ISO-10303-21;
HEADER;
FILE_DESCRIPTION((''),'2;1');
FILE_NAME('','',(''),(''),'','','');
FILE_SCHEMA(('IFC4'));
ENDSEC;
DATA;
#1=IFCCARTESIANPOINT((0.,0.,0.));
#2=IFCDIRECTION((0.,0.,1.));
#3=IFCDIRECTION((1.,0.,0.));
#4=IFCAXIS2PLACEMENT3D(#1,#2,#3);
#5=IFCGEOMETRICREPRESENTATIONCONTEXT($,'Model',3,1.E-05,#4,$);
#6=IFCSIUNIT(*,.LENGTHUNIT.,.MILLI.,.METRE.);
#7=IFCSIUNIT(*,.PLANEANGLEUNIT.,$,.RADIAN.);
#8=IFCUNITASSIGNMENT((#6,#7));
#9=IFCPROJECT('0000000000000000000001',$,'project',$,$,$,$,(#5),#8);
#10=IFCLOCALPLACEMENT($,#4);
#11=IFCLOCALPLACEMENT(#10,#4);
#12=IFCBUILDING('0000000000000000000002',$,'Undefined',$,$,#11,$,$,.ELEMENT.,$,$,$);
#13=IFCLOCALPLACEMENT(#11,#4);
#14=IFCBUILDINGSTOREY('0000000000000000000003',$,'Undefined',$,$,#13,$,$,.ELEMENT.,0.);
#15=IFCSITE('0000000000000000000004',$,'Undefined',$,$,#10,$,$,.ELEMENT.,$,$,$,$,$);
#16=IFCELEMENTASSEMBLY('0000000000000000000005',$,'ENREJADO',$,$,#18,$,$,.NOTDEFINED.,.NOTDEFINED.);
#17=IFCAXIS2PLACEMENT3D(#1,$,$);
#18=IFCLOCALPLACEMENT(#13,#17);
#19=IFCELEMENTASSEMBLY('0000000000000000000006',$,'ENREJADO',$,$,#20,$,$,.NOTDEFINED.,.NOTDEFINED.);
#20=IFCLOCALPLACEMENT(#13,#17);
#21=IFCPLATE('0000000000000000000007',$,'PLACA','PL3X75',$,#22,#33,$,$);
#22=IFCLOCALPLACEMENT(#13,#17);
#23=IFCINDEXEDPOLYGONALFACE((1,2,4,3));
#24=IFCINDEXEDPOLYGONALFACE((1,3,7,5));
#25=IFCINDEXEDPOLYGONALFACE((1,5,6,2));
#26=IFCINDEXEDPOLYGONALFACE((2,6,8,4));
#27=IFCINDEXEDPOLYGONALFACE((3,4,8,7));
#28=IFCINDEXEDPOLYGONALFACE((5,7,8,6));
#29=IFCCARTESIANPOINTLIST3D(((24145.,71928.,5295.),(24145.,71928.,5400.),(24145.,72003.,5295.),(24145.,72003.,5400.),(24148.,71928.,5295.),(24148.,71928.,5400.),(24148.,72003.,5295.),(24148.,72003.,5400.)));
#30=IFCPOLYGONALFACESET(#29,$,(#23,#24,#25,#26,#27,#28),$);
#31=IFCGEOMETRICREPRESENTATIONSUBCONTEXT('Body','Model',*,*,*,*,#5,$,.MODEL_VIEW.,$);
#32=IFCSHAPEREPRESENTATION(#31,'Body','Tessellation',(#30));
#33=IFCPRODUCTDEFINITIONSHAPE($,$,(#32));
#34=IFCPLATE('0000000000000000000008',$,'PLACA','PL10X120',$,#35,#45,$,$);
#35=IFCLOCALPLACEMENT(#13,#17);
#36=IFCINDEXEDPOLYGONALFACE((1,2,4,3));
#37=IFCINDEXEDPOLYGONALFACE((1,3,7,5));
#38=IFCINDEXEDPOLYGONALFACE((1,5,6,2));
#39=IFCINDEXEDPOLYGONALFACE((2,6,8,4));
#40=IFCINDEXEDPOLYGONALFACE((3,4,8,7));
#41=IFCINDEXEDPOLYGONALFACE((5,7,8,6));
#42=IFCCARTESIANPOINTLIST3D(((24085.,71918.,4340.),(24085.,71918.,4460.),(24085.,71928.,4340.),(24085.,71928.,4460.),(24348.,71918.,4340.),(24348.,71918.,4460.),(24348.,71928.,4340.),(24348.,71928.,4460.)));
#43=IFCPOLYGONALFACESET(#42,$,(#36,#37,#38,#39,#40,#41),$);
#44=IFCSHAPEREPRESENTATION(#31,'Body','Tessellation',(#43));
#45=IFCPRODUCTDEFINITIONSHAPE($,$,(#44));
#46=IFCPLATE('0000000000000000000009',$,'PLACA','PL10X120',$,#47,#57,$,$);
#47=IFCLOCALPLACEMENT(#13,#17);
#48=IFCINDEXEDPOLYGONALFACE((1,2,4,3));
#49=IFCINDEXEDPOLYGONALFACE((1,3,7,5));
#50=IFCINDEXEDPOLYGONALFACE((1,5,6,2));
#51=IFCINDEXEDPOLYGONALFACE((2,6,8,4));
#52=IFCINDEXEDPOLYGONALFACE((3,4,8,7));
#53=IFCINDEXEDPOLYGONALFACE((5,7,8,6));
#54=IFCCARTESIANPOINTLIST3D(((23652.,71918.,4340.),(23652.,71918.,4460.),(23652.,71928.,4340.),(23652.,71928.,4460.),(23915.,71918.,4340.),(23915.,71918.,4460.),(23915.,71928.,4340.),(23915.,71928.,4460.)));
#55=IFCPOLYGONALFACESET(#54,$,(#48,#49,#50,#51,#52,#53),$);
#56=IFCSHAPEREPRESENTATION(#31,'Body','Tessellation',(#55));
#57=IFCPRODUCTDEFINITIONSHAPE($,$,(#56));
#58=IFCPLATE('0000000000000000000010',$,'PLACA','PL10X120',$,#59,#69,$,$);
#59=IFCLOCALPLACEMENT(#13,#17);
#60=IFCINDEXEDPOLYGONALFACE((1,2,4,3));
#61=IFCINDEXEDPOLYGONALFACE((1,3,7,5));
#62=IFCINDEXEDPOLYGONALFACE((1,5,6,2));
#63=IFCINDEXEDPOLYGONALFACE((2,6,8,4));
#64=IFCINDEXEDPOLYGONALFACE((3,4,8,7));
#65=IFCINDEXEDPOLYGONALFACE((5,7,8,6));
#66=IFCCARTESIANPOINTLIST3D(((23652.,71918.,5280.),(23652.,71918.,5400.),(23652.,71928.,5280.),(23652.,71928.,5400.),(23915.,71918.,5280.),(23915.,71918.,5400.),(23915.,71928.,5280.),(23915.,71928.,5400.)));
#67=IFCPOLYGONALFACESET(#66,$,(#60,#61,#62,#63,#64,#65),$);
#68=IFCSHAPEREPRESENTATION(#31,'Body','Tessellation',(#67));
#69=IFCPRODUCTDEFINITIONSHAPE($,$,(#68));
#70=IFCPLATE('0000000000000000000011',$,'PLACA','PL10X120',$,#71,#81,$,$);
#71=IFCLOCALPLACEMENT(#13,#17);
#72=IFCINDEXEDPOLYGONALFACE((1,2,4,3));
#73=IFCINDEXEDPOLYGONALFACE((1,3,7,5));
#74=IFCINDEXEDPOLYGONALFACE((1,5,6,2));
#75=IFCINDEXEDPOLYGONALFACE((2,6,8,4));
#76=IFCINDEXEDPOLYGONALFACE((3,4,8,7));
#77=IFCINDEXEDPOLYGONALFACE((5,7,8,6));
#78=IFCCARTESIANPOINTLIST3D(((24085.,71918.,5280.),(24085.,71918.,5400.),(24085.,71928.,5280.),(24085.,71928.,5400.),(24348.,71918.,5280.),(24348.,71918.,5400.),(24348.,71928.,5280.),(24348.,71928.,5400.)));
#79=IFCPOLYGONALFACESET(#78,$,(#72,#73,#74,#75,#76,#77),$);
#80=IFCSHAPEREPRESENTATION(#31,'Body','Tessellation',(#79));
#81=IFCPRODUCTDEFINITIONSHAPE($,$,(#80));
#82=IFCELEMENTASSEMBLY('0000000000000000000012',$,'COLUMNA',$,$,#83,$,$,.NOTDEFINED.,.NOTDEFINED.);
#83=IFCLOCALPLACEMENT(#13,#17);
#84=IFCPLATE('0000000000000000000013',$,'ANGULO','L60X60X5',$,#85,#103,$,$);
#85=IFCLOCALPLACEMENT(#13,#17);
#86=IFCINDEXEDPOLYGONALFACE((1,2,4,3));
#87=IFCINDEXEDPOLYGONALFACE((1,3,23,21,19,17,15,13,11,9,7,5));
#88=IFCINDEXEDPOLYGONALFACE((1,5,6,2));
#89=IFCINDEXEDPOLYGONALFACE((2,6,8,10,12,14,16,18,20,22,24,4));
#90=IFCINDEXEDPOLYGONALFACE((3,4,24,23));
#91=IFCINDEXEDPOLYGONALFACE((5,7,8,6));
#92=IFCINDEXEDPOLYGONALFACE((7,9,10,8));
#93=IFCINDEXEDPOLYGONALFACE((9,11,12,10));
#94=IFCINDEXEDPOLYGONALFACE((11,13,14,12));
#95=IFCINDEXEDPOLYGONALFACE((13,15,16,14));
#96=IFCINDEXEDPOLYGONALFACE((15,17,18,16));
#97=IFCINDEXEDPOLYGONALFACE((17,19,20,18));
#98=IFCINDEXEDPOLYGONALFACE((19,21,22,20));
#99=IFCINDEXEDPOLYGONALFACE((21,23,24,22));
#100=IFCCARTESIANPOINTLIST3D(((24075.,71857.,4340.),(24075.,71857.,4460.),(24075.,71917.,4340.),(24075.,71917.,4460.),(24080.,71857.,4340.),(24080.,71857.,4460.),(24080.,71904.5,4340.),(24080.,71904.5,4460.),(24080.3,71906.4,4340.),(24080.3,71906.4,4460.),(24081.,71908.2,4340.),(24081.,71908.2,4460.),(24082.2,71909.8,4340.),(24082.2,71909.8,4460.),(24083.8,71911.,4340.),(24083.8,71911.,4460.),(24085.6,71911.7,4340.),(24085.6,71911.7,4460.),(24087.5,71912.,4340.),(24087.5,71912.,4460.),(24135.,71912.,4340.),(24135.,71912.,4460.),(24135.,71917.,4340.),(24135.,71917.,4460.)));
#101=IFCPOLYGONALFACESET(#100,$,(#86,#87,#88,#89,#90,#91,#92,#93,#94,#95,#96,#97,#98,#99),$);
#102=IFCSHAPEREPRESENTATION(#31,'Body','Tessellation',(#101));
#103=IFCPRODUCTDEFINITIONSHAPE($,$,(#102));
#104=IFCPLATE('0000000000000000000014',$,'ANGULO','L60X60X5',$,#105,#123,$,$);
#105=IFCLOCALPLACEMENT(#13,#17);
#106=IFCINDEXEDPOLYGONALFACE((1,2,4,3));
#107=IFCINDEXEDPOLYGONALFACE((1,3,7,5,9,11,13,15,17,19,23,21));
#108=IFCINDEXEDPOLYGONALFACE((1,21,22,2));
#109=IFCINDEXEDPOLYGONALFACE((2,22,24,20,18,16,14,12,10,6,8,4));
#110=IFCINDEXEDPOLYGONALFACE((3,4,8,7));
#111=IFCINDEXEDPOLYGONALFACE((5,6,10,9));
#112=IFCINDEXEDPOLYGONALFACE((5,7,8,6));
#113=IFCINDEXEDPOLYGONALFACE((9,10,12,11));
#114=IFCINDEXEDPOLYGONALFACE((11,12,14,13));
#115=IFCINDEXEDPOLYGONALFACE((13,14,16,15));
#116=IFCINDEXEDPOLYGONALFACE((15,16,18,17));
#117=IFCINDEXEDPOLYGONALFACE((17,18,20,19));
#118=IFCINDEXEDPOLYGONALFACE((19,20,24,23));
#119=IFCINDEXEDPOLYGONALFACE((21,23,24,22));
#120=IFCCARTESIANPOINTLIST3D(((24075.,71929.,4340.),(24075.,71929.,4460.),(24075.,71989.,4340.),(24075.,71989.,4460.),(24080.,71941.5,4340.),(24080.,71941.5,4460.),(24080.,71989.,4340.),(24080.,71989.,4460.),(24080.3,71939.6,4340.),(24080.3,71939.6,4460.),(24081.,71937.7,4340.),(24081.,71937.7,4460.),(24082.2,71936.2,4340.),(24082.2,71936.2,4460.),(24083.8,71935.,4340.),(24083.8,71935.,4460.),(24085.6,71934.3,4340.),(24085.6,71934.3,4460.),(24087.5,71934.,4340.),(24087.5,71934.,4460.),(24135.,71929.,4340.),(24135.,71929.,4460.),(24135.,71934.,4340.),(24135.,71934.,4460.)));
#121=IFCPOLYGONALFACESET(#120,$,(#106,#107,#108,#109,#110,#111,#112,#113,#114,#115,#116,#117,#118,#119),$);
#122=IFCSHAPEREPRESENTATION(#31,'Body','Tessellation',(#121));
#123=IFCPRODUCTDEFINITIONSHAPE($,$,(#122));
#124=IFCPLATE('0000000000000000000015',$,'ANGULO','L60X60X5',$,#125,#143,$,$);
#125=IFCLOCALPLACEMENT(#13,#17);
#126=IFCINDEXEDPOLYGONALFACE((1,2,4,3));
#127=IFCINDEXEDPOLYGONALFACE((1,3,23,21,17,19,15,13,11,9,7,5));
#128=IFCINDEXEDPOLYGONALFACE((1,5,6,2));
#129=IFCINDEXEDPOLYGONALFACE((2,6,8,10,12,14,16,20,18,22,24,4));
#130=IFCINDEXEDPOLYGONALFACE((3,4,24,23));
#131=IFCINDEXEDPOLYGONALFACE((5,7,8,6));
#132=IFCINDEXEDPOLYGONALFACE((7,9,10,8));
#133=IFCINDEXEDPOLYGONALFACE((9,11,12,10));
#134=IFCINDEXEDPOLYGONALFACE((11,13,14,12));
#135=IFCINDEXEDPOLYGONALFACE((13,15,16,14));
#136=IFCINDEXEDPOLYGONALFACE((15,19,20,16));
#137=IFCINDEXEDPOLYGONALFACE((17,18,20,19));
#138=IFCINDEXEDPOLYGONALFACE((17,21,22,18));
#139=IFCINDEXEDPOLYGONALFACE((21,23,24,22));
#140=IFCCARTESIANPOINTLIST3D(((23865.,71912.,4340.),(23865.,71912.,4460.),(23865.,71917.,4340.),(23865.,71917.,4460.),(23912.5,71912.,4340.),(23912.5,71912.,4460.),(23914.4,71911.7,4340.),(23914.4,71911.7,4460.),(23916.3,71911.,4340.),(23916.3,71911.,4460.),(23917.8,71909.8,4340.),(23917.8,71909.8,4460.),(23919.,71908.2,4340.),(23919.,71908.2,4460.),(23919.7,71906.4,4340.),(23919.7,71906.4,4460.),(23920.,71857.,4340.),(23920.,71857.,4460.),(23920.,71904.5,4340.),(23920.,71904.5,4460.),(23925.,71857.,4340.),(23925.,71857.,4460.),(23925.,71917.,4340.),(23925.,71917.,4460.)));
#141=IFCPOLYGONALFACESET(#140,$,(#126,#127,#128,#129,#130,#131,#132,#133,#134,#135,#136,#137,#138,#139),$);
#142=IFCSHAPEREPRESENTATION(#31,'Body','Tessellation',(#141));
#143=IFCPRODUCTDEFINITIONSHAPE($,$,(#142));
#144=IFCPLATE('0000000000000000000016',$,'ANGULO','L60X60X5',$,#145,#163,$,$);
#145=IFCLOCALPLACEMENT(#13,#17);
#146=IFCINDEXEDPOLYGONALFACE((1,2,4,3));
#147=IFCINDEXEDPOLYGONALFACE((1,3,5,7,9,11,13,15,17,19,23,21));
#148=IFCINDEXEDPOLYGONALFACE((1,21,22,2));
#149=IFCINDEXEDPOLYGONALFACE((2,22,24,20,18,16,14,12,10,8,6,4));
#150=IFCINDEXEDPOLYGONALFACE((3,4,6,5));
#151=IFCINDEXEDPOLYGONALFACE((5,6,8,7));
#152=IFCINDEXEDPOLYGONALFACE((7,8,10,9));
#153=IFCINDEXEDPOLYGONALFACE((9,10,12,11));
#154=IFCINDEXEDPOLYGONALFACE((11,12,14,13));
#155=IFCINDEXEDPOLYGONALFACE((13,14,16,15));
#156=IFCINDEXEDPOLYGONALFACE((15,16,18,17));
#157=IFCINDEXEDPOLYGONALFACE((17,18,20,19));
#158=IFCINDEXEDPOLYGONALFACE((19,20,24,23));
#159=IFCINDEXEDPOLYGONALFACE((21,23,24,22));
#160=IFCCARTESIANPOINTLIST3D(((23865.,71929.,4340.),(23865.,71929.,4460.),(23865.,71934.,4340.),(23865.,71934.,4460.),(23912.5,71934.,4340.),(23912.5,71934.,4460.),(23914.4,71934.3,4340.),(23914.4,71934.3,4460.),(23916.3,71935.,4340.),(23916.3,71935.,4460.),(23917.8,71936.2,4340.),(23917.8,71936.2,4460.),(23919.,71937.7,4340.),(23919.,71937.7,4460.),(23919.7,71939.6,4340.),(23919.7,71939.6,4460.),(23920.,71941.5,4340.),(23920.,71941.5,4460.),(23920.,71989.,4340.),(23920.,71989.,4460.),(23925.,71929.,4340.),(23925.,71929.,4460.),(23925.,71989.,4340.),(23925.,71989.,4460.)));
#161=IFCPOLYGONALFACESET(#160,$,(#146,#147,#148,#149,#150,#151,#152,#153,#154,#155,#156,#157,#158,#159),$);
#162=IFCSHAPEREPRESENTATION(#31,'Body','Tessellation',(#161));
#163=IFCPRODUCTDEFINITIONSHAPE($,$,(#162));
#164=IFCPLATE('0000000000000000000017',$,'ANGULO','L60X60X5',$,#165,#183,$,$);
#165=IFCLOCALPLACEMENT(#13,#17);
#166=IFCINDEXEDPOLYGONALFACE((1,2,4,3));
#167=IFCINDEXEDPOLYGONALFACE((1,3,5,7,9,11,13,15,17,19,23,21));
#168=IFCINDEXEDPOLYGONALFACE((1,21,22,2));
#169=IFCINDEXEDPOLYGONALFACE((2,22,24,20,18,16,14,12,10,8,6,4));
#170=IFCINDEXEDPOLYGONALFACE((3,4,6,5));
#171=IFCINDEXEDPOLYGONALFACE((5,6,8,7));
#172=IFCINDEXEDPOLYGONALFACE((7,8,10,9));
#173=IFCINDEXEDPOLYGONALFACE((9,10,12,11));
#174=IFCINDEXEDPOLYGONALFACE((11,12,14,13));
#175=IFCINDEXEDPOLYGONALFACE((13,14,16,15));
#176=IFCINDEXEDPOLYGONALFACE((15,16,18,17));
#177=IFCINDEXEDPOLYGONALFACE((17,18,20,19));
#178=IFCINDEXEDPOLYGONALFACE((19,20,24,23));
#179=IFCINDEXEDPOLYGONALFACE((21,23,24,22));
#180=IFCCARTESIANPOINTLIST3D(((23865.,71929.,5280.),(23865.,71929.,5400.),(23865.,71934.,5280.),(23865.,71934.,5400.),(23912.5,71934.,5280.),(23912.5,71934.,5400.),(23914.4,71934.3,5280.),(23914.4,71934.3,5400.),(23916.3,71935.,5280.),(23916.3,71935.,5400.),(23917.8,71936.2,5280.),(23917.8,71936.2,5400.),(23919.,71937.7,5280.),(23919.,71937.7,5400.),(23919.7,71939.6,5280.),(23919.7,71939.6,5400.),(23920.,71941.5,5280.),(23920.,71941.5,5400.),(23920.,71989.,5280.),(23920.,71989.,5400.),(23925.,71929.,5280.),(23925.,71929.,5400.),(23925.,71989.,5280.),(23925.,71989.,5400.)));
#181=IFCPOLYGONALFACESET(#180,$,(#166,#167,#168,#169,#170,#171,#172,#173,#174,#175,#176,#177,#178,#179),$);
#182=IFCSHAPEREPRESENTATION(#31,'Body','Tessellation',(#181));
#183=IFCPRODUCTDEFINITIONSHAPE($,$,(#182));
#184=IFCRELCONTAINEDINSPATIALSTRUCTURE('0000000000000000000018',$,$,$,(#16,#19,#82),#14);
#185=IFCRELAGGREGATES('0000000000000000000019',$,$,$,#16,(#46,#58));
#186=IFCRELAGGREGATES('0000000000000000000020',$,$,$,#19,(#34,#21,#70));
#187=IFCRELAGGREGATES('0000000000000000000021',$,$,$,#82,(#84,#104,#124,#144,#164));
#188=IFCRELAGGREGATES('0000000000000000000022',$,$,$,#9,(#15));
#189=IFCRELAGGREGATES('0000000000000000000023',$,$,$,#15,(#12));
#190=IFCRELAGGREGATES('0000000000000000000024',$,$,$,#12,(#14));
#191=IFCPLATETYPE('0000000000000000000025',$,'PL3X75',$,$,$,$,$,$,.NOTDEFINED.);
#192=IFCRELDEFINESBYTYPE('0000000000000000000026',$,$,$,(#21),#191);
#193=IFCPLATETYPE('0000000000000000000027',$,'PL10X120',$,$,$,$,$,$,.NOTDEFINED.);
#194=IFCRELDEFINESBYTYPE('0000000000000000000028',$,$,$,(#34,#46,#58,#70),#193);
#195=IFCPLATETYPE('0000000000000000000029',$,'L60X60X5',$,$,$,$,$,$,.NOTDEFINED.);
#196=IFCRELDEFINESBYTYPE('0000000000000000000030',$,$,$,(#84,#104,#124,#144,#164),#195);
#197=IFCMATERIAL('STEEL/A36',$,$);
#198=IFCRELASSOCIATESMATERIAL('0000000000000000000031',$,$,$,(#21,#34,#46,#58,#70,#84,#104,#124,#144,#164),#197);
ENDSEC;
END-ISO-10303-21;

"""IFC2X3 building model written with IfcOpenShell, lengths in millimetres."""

from ifc_helpers import new_model, si_unit, frame, origin_with_axes, origin_2d_with_axis, place, context, subcontext, project, spatial, polyline, l_section, outline, extrude, material, type_object, element, aggregate, save


model = new_model("IFC2X3")

# Units and contexts
model_context = context("Model", 3, precision=1e-05, world=origin_with_axes())
body_context = subcontext(model_context, "Body", "Model", "MODEL_VIEW")
ifc_project = project(units=[si_unit("LENGTHUNIT", "METRE", prefix="MILLI"), si_unit("PLANEANGLEUNIT", "RADIAN")], contexts=[model_context])

# Site, building, storey
site_placement = place(None, origin_with_axes())
site = spatial("IfcSite", under=ifc_project, at=site_placement, Name="Undefined", CompositionType="ELEMENT")
building_placement = place(site_placement, origin_with_axes())
building = spatial("IfcBuilding", under=site, at=building_placement, Name="Undefined", CompositionType="ELEMENT")
storey_placement = place(building_placement, origin_with_axes())
storey = spatial("IfcBuildingStorey", under=building, at=storey_placement, Name="Undefined", CompositionType="ELEMENT", Elevation=0.0)

# Element assemblies
assembly_1_placement = place(storey_placement, origin_with_axes())
assembly_1 = element("IfcElementAssembly", 1, at=assembly_1_placement, inside=storey, Name="ENREJADO", AssemblyPlace="NOTDEFINED", PredefinedType="NOTDEFINED")
ifc_material_1 = material(Name="STEEL/A36")
assembly_2_placement = place(storey_placement, origin_with_axes())
assembly_2 = element("IfcElementAssembly", 2, at=assembly_2_placement, inside=storey, Name="ENREJADO", AssemblyPlace="NOTDEFINED", PredefinedType="NOTDEFINED")

# Plates
plate_type_1 = type_object("IfcPlateType", Name="PL3X75", PredefinedType="NOTDEFINED")
plate_1_placement = place(assembly_2_placement, frame((24146.5, 71928.0, 5295.0), z_axis=(1.0, 0.0, 0.0), x_axis=(0.0, 1.0, 0.0)))
plate_1 = element("IfcPlate", 3, at=plate_1_placement, type_object=plate_type_1, material=ifc_material_1, Name="PLACA", Description="PL3X75", context=body_context, shape_type="SweptSolid", body=[
    extrude(outline(polyline([(0.0, 0.0), (75.0, 0.0), (75.0, 105.0), (0.0, 105.0), (0.0, 0.0)])), frame((0.0, 0.0, -1.5), z_axis=(0.0, 0.0, 1.0), x_axis=(1.0, 0.0, 0.0)), (0.0, 0.0, 1.0), 3.0),
])
plate_type_2 = type_object("IfcPlateType", Name="PL10X120", PredefinedType="NOTDEFINED")
plate_2_placement = place(assembly_2_placement, frame((24085.0, 71923.0, 4400.0), z_axis=(0.0, 1.0, 0.0), x_axis=(1.0, 0.0, 0.0)))
plate_2 = element("IfcPlate", 4, at=plate_2_placement, type_object=plate_type_2, material=ifc_material_1, Name="PLACA", Description="PL10X120", context=body_context, shape_type="SweptSolid", body=[
    extrude(outline(polyline([(0.0, -60.0), (0.0, 60.0), (263.0, 60.0), (263.0, -60.0), (0.0, -60.0)])), frame((0.0, 0.0, -5.0), z_axis=(0.0, 0.0, 1.0), x_axis=(1.0, 0.0, 0.0)), (0.0, 0.0, 1.0), 10.0),
])
plate_3_placement = place(assembly_1_placement, frame((23915.0, 71923.0, 4400.0), z_axis=(0.0, 1.0, 0.0), x_axis=(-1.0, 0.0, 0.0)))
plate_3 = element("IfcPlate", 5, at=plate_3_placement, type_object=plate_type_2, material=ifc_material_1, Name="PLACA", Description="PL10X120", context=body_context, shape_type="SweptSolid", body=[
    extrude(outline(polyline([(0.0, -60.0), (0.0, 60.0), (263.0, 60.0), (263.0, -60.0), (0.0, -60.0)])), frame((0.0, 0.0, -5.0), z_axis=(0.0, 0.0, 1.0), x_axis=(1.0, 0.0, 0.0)), (0.0, 0.0, 1.0), 10.0),
])
plate_4_placement = place(assembly_1_placement, frame((23915.0, 71923.0, 5340.0), z_axis=(0.0, -1.0, 0.0), x_axis=(-1.0, 0.0, 0.0)))
plate_4 = element("IfcPlate", 6, at=plate_4_placement, type_object=plate_type_2, material=ifc_material_1, Name="PLACA", Description="PL10X120", context=body_context, shape_type="SweptSolid", body=[
    extrude(outline(polyline([(0.0, -60.0), (0.0, 60.0), (263.0, 60.0), (263.0, -60.0), (0.0, -60.0)])), frame((0.0, 0.0, -5.0), z_axis=(0.0, 0.0, 1.0), x_axis=(1.0, 0.0, 0.0)), (0.0, 0.0, 1.0), 10.0),
])
aggregate(assembly_1, [plate_3, plate_4])
plate_5_placement = place(assembly_2_placement, frame((24085.0, 71923.0, 5340.0), z_axis=(0.0, 1.0, 0.0), x_axis=(1.0, 0.0, 0.0)))
plate_5 = element("IfcPlate", 7, at=plate_5_placement, type_object=plate_type_2, material=ifc_material_1, Name="PLACA", Description="PL10X120", context=body_context, shape_type="SweptSolid", body=[
    extrude(outline(polyline([(0.0, -60.0), (0.0, 60.0), (263.0, 60.0), (263.0, -60.0), (0.0, -60.0)])), frame((0.0, 0.0, -5.0), z_axis=(0.0, 0.0, 1.0), x_axis=(1.0, 0.0, 0.0)), (0.0, 0.0, 1.0), 10.0),
])
aggregate(assembly_2, [plate_2, plate_1, plate_5])

# Element assembly, plates
assembly_3_placement = place(storey_placement, origin_with_axes())
assembly_3 = element("IfcElementAssembly", 8, at=assembly_3_placement, inside=storey, Name="COLUMNA", AssemblyPlace="NOTDEFINED", PredefinedType="NOTDEFINED")
plate_type_3 = type_object("IfcPlateType", Name="L60X60X5", PredefinedType="NOTDEFINED")
plate_6_placement = place(assembly_3_placement, frame((24105.0, 71887.0, 4340.0), z_axis=(0.0, -1.0, 0.0), x_axis=(0.0, 0.0, 1.0)))
plate_6 = element("IfcPlate", 9, at=plate_6_placement, type_object=plate_type_3, material=ifc_material_1, Name="ANGULO", Description="L60X60X5", context=body_context, shape_type="SweptSolid", body=[
    extrude(l_section(Depth=60.0, Width=60.0, Thickness=5.0, FilletRadius=7.5, at=origin_2d_with_axis()), frame((120.0, 0.0, 0.0), z_axis=(-1.0, 0.0, 0.0), x_axis=(0.0, -1.0, 0.0)), (0.0, 0.0, 1.0), 120.0),
])
plate_7_placement = place(assembly_3_placement, frame((24105.0, 71959.0, 4460.0), z_axis=(0.0, 1.0, 0.0), x_axis=(0.0, 0.0, -1.0)))
plate_7 = element("IfcPlate", 10, at=plate_7_placement, type_object=plate_type_3, material=ifc_material_1, Name="ANGULO", Description="L60X60X5", context=body_context, shape_type="SweptSolid", body=[
    extrude(l_section(Depth=60.0, Width=60.0, Thickness=5.0, FilletRadius=7.5, at=origin_2d_with_axis()), frame((120.0, 0.0, 0.0), z_axis=(-1.0, 0.0, 0.0), x_axis=(0.0, -1.0, 0.0)), (0.0, 0.0, 1.0), 120.0),
])
plate_8_placement = place(assembly_3_placement, frame((23895.0, 71887.0, 4460.0), z_axis=(0.0, -1.0, 0.0), x_axis=(0.0, 0.0, -1.0)))
plate_8 = element("IfcPlate", 11, at=plate_8_placement, type_object=plate_type_3, material=ifc_material_1, Name="ANGULO", Description="L60X60X5", context=body_context, shape_type="SweptSolid", body=[
    extrude(l_section(Depth=60.0, Width=60.0, Thickness=5.0, FilletRadius=7.5, at=origin_2d_with_axis()), frame((120.0, 0.0, 0.0), z_axis=(-1.0, 0.0, 0.0), x_axis=(0.0, -1.0, 0.0)), (0.0, 0.0, 1.0), 120.0),
])
plate_9_placement = place(assembly_3_placement, frame((23895.0, 71959.0, 4340.0), z_axis=(0.0, 1.0, 0.0), x_axis=(0.0, 0.0, 1.0)))
plate_9 = element("IfcPlate", 12, at=plate_9_placement, type_object=plate_type_3, material=ifc_material_1, Name="ANGULO", Description="L60X60X5", context=body_context, shape_type="SweptSolid", body=[
    extrude(l_section(Depth=60.0, Width=60.0, Thickness=5.0, FilletRadius=7.5, at=origin_2d_with_axis()), frame((120.0, 0.0, 0.0), z_axis=(-1.0, 0.0, 0.0), x_axis=(0.0, -1.0, 0.0)), (0.0, 0.0, 1.0), 120.0),
])
plate_10_placement = place(assembly_3_placement, frame((23895.0, 71959.0, 5280.0), z_axis=(0.0, 1.0, 0.0), x_axis=(0.0, 0.0, 1.0)))
plate_10 = element("IfcPlate", 13, at=plate_10_placement, type_object=plate_type_3, material=ifc_material_1, Name="ANGULO", Description="L60X60X5", context=body_context, shape_type="SweptSolid", body=[
    extrude(l_section(Depth=60.0, Width=60.0, Thickness=5.0, FilletRadius=7.5, at=origin_2d_with_axis()), frame((120.0, 0.0, 0.0), z_axis=(-1.0, 0.0, 0.0), x_axis=(0.0, -1.0, 0.0)), (0.0, 0.0, 1.0), 120.0),
])

aggregate(assembly_3, [plate_6, plate_7, plate_8, plate_9, plate_10])

save(model, "model.ifc")
